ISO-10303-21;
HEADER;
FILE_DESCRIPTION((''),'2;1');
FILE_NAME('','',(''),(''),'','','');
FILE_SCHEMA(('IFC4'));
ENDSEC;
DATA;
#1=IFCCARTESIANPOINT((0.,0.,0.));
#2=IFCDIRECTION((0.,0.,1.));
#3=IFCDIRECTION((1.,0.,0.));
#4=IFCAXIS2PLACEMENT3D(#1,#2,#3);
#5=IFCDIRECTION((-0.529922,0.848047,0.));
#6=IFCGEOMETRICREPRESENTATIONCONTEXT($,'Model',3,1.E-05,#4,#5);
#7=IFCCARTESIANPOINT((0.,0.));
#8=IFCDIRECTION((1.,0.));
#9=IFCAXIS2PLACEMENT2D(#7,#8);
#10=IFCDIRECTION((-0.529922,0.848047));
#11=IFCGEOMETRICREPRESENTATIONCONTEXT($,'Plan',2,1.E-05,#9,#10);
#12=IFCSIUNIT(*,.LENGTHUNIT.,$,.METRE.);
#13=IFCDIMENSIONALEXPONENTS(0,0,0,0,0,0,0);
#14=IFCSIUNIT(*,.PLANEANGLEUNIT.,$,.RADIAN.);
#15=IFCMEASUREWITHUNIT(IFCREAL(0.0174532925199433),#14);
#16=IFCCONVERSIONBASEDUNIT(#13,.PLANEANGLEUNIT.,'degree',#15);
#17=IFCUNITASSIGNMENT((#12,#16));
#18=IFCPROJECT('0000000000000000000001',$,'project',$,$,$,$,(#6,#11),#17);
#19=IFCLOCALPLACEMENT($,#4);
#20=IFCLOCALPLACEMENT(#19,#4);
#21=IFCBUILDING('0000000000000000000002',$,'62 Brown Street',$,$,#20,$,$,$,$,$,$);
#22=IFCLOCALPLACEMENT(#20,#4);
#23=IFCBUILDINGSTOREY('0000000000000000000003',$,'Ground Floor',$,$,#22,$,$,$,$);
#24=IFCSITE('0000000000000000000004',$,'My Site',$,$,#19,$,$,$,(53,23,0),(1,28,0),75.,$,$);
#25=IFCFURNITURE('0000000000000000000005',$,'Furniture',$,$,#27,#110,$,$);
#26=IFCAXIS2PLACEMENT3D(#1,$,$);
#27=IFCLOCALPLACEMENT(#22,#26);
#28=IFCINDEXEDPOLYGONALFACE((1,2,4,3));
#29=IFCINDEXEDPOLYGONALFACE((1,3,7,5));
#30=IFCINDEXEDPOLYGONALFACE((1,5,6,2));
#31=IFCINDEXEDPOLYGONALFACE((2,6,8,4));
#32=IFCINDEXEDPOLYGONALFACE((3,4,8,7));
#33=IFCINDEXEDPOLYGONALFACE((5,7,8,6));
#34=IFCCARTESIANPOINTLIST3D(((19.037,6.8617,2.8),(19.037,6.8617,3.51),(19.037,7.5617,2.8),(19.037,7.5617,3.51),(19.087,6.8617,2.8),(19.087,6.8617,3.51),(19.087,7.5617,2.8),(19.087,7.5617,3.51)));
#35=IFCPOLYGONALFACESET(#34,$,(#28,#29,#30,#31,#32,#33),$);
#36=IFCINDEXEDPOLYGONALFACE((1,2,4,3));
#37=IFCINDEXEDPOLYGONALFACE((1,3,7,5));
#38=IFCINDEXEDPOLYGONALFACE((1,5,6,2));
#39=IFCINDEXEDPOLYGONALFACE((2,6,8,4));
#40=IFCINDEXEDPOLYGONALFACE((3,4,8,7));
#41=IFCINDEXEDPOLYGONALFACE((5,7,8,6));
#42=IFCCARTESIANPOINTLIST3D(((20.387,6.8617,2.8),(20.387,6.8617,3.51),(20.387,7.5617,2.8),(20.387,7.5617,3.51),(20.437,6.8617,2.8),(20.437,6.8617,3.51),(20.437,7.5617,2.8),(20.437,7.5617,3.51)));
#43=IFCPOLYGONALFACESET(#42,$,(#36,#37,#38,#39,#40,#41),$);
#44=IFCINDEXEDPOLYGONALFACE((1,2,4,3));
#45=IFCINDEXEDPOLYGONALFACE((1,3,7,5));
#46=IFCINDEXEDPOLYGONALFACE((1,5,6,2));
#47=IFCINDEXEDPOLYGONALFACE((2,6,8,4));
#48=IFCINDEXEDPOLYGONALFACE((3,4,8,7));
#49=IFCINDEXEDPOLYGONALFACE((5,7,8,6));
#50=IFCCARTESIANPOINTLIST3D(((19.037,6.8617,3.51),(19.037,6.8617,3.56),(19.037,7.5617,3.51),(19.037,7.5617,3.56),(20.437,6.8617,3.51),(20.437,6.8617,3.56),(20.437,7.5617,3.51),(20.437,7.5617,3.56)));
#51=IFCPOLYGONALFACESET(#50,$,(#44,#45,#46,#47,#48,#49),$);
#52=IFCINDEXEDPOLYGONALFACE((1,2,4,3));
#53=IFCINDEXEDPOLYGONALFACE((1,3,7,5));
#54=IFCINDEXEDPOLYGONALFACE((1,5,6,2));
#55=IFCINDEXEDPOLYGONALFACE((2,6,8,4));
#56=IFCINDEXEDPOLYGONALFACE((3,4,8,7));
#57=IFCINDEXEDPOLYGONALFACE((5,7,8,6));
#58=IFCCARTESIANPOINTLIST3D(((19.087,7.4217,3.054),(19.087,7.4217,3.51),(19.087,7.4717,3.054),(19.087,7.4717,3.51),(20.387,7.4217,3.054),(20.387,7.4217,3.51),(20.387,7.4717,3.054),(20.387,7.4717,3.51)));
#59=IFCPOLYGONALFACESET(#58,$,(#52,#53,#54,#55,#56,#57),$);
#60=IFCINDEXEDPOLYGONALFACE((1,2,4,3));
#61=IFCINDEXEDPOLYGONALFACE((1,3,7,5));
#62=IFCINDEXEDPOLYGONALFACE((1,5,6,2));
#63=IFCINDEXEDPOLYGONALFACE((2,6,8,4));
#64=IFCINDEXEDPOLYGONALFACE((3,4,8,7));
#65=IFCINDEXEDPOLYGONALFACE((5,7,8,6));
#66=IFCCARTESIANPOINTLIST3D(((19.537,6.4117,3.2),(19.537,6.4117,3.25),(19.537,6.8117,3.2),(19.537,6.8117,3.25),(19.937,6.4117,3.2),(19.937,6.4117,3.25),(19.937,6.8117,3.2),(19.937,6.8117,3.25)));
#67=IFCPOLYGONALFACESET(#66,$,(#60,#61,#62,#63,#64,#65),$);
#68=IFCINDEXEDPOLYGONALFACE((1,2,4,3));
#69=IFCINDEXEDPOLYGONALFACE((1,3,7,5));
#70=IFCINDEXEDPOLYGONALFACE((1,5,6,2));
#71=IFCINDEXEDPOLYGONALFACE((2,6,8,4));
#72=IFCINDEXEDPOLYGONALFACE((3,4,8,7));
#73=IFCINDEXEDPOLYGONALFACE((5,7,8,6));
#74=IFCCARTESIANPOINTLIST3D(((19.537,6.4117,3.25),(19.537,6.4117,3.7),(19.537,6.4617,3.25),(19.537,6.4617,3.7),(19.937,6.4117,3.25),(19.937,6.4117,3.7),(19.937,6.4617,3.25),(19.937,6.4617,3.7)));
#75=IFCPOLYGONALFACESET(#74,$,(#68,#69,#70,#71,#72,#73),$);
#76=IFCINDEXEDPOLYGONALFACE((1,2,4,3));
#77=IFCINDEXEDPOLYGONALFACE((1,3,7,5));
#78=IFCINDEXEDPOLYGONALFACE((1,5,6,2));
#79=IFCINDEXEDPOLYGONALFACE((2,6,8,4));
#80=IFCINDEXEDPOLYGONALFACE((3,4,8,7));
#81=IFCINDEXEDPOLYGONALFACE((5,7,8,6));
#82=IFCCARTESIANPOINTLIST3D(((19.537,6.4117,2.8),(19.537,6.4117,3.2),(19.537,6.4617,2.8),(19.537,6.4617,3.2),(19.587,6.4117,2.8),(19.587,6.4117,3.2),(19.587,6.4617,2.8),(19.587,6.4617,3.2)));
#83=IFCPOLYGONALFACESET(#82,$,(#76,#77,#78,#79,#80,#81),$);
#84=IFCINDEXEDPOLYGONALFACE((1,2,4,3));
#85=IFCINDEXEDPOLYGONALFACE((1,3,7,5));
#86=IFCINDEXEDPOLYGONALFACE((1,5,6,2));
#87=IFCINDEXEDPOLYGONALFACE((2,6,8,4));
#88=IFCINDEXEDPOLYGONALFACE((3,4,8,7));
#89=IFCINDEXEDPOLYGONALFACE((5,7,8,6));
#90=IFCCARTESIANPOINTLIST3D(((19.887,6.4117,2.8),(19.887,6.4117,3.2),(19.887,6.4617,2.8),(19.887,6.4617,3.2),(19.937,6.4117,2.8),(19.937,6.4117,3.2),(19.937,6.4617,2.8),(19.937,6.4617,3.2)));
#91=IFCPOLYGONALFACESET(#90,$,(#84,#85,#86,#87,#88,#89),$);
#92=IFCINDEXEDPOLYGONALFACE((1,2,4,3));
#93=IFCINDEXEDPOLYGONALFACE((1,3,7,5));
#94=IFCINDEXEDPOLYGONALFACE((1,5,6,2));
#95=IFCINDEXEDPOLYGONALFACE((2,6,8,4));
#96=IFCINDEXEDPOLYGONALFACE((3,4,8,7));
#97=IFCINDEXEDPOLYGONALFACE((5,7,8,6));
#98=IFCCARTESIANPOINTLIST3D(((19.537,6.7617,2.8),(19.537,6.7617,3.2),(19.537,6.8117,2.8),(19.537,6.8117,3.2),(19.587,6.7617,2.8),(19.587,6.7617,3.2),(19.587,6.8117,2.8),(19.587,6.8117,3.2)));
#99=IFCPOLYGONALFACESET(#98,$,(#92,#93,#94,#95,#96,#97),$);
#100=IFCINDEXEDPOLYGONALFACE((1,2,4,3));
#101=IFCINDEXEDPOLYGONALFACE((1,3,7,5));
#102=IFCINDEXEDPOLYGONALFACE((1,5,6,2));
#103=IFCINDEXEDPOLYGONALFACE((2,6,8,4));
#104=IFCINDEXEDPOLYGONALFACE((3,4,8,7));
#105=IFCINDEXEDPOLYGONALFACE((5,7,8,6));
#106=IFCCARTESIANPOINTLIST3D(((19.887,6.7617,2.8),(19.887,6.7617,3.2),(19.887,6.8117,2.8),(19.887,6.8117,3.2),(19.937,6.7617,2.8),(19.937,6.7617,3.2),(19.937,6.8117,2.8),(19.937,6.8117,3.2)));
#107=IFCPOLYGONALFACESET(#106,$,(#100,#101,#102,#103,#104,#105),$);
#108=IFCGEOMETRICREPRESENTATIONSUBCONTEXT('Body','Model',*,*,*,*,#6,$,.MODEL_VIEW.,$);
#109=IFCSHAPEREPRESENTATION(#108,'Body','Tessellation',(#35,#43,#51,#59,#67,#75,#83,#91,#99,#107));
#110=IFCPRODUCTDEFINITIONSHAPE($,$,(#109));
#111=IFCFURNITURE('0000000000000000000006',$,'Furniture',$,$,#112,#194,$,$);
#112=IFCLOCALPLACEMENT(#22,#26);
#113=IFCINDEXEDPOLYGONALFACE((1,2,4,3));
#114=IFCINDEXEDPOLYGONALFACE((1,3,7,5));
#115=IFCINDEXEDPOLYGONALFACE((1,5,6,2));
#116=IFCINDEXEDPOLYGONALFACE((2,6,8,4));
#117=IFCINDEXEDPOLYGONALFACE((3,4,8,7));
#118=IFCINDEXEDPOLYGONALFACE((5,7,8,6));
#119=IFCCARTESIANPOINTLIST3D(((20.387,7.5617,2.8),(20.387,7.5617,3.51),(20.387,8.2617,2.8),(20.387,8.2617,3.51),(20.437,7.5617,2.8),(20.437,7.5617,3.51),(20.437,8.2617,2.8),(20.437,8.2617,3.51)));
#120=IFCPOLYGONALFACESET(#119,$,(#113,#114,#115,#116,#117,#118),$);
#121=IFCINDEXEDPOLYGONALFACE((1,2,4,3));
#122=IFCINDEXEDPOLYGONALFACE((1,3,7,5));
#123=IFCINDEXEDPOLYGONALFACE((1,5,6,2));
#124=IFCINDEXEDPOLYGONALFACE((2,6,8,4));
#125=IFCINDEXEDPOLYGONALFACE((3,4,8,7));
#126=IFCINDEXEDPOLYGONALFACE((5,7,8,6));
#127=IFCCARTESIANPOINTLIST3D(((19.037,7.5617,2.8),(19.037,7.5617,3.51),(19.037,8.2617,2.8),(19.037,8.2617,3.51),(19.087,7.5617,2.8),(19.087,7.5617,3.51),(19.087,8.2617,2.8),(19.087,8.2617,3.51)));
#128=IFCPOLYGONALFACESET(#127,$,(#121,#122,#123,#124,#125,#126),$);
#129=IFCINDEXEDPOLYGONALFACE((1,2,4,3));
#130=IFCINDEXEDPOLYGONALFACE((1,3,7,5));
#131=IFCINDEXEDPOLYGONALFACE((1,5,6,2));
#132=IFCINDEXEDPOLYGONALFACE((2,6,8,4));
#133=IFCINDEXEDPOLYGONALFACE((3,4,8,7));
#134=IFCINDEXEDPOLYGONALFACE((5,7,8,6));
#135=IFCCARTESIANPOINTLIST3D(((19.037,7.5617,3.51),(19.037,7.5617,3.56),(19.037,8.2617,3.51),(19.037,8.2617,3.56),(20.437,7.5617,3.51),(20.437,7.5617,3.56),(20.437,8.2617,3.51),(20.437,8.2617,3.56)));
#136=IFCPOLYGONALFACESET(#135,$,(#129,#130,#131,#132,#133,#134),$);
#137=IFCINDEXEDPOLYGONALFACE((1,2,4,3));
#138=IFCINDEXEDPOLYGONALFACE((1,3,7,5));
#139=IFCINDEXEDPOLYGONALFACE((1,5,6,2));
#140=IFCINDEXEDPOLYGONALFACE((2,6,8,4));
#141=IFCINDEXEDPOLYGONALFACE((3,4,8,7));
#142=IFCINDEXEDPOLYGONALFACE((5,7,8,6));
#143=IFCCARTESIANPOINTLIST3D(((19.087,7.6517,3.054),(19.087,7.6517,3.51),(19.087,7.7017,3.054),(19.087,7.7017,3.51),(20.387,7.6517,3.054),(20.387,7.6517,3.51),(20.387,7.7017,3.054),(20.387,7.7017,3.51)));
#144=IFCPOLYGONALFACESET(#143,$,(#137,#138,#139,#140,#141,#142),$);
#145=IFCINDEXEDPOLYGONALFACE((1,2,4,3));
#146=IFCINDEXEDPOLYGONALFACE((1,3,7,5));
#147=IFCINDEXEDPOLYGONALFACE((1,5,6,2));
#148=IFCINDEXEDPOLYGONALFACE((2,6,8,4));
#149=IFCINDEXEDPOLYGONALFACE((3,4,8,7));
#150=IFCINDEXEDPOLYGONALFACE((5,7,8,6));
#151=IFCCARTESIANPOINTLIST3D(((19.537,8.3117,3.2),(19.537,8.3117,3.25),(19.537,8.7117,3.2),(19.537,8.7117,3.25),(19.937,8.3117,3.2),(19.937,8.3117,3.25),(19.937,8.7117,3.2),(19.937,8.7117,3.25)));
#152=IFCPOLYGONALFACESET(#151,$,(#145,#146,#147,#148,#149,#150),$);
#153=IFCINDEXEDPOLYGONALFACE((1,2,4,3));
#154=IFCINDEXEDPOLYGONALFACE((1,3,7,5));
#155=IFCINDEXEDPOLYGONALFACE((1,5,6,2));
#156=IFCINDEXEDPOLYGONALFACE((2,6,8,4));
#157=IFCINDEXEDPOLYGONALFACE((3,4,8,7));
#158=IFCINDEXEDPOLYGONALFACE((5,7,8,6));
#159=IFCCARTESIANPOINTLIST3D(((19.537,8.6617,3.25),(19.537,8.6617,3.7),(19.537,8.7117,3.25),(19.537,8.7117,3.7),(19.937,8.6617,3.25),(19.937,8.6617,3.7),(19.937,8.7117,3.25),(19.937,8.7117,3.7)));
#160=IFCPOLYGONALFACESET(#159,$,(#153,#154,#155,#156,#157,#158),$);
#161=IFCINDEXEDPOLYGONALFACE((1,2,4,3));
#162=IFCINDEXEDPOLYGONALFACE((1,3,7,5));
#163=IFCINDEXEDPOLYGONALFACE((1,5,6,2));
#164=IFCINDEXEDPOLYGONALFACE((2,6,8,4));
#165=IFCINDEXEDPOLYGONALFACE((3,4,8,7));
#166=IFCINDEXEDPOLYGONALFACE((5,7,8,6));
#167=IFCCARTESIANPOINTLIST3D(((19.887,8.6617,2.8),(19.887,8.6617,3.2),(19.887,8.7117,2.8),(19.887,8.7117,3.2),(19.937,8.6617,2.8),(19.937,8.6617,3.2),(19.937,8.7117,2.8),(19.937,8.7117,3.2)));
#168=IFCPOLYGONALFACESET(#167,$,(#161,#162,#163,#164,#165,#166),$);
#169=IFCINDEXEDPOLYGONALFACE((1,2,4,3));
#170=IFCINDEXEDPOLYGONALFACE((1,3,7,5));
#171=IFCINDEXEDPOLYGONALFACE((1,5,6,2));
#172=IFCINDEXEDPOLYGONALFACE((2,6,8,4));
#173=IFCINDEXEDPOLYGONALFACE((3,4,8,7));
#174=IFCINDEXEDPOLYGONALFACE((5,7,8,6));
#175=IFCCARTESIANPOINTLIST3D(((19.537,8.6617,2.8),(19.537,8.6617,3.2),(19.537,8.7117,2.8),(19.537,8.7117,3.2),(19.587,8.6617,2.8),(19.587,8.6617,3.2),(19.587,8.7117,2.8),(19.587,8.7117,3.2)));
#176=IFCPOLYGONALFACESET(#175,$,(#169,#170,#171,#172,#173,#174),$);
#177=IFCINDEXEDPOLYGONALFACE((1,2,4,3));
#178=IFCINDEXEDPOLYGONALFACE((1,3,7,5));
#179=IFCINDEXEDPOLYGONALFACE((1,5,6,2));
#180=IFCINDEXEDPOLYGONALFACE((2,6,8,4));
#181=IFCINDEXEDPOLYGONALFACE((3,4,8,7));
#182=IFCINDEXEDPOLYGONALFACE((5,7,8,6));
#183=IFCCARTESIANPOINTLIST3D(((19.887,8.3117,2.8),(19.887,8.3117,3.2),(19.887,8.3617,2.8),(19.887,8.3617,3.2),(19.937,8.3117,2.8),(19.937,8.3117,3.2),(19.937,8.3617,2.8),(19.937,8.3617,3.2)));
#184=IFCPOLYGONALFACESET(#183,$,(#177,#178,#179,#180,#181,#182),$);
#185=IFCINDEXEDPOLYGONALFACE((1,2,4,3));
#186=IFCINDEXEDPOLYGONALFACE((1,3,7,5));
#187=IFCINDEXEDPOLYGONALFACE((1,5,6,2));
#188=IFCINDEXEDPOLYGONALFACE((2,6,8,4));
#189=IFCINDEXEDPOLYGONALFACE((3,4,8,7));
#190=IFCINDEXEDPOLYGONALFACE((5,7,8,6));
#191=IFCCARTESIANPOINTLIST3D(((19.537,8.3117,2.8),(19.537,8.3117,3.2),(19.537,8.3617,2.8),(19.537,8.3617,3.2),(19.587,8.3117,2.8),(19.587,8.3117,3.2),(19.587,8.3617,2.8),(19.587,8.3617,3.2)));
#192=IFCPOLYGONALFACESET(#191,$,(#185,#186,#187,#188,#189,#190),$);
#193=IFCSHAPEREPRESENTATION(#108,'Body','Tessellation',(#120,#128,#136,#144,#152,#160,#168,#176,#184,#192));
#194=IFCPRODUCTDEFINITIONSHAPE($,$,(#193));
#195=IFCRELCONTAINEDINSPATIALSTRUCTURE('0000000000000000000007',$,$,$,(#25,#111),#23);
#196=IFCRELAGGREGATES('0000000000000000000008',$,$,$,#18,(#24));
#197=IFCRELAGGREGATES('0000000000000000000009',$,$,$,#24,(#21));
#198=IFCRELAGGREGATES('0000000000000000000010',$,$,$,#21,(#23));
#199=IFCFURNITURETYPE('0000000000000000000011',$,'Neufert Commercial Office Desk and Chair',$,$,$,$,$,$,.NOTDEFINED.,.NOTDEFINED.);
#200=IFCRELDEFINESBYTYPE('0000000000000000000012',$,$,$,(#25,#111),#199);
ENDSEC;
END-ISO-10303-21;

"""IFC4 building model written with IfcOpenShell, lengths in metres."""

from ifc_helpers import new_model, entity, si_unit, converted_unit, direction, frame, origin_with_axes, origin_2d_with_axis, place, context, subcontext, project, spatial, line, indexed_curve, outline, extrude, shape, source, transform, mapped, type_object, type_shapes, element, save


model = new_model("IFC4")

# Units and contexts
model_context = context("Model", 3, precision=1e-05, world=origin_with_axes(), true_north=direction((-0.529922, 0.848047, 0.0)))
plan_context = context("Plan", 2, precision=1e-05, world=origin_2d_with_axis(), true_north=direction((-0.529922, 0.848047)))
body_context_1 = subcontext(model_context, "Body", "Model", "MODEL_VIEW")
body_context_2 = subcontext(plan_context, "Body", "Plan", "PLAN_VIEW")
ifc_project = project(units=[si_unit("LENGTHUNIT", "METRE"), converted_unit("PLANEANGLEUNIT", "degree", entity("IfcReal", 0.0174532925199433), si_unit("PLANEANGLEUNIT", "RADIAN"), dimensions=[0, 0, 0, 0, 0, 0, 0])], contexts=[model_context, plan_context])

# Site, building, storey
site_placement = place(None, origin_with_axes())
site = spatial("IfcSite", under=ifc_project, at=site_placement, Name="My Site", RefLatitude=(53, 23, 0), RefLongitude=(1, 28, 0), RefElevation=75.0)
building_placement = place(site_placement, origin_with_axes())
building = spatial("IfcBuilding", under=site, at=building_placement, Name="62 Brown Street")
storey_placement = place(building_placement, origin_with_axes())
storey = spatial("IfcBuildingStorey", under=building, at=storey_placement, Name="Ground Floor")

# Furniture
furniture_type_1 = type_object("IfcFurnitureType", Name="Neufert Commercial Office Desk and Chair", AssemblyPlace="NOTDEFINED", PredefinedType="NOTDEFINED")
shared_shape_1 = source(origin_with_axes(), body_context_1, "Body", "SweptSolid", [
    extrude(outline(indexed_curve([(0.0, 0.0), (0.05, 0.0), (0.05, 0.7), (0.0, 0.7)], segments=[line(1, 2, 3, 4, 1)])), frame((0.0, 0.45, 0.0), z_axis=(0.0, 0.0, 1.0), x_axis=(1.0, 0.0, 0.0)), (0.0, 0.0, 1.0), 0.71),
    extrude(outline(indexed_curve([(0.0, 0.0), (0.05, 0.0), (0.05, 0.7), (0.0, 0.7)], segments=[line(1, 2, 3, 4, 1)])), frame((1.35, 0.45, 0.0), z_axis=(0.0, 0.0, 1.0), x_axis=(1.0, 0.0, 0.0)), (0.0, 0.0, 1.0), 0.71),
    extrude(outline(indexed_curve([(0.0, 0.0), (1.4, 0.0), (1.4, 0.7), (0.0, 0.7)], segments=[line(1, 2, 3, 4, 1)])), frame((0.0, 0.45, 0.71), z_axis=(0.0, 0.0, 1.0), x_axis=(1.0, 0.0, 0.0)), (0.0, 0.0, 1.0), 0.05),
    extrude(outline(indexed_curve([(0.05, 0.56), (1.35, 0.56), (1.35, 0.61), (0.05, 0.61)], segments=[line(1, 2, 3, 4, 1)])), frame((0.0, 0.45, 0.254), z_axis=(0.0, 0.0, 1.0), x_axis=(1.0, 0.0, 0.0)), (0.0, 0.0, 1.0), 0.456),
    extrude(outline(indexed_curve([(-0.2, 0.0), (0.2, 0.0), (0.2, 0.4), (-0.2, 0.4)], segments=[line(1, 2, 3, 4, 1)])), frame((0.7, 0.0, 0.45), z_axis=(0.0, 0.0, 1.0), x_axis=(1.0, 0.0, 0.0)), (0.0, 0.0, -1.0), 0.05),
    extrude(outline(indexed_curve([(-0.2, 0.0), (0.2, 0.0), (0.2, 0.05), (-0.2, 0.05)], segments=[line(1, 2, 3, 4, 1)])), frame((0.7, 0.0, 0.9), z_axis=(0.0, 0.0, 1.0), x_axis=(1.0, 0.0, 0.0)), (0.0, 0.0, -1.0), 0.45),
    extrude(outline(indexed_curve([(-0.2, 0.0), (-0.15, 0.0), (-0.15, 0.05), (-0.2, 0.05)], segments=[line(1, 2, 3, 4, 1)])), frame((0.7, 0.0, 0.0), z_axis=(0.0, 0.0, 1.0), x_axis=(1.0, 0.0, 0.0)), (0.0, 0.0, 1.0), 0.4),
    extrude(outline(indexed_curve([(0.2, 0.0), (0.15, 0.0), (0.15, 0.05), (0.2, 0.05)], segments=[line(1, 2, 3, 4, 1)])), frame((0.7, 0.0, 0.0), z_axis=(0.0, 0.0, 1.0), x_axis=(1.0, 0.0, 0.0)), (0.0, 0.0, 1.0), 0.4),
    extrude(outline(indexed_curve([(-0.2, 0.4), (-0.15, 0.4), (-0.15, 0.35), (-0.2, 0.35)], segments=[line(1, 2, 3, 4, 1)])), frame((0.7, 0.0, 0.0), z_axis=(0.0, 0.0, 1.0), x_axis=(1.0, 0.0, 0.0)), (0.0, 0.0, 1.0), 0.4),
    extrude(outline(indexed_curve([(0.2, 0.4), (0.15, 0.4), (0.15, 0.35), (0.2, 0.35)], segments=[line(1, 2, 3, 4, 1)])), frame((0.7, 0.0, 0.0), z_axis=(0.0, 0.0, 1.0), x_axis=(1.0, 0.0, 0.0)), (0.0, 0.0, 1.0), 0.4),
])
shared_shape_2 = source(origin_with_axes(), body_context_2, "Body", "Curve2D", [
    entity("IfcIndexedPolyCurve", entity("IfcCartesianPointList2D", [[0.0, 0.45], [1.4, 0.45], [1.4, 1.15], [0.0, 1.15]]), [entity("IfcLineIndex", [1, 2, 3, 4, 1])]),
    entity("IfcIndexedPolyCurve", entity("IfcCartesianPointList2D", [[0.5, 0.4], [0.9, 0.4]])),
    entity("IfcIndexedPolyCurve", entity("IfcCartesianPointList2D", [[0.5, 0.4], [0.5, 0.2], [0.5586, 0.0586], [0.7, 0.0], [0.8414, 0.0586], [0.9, 0.2], [0.9, 0.4]]), [entity("IfcLineIndex", [1, 2]), entity("IfcArcIndex", [2, 3, 4]), entity("IfcArcIndex", [4, 5, 6]), entity("IfcLineIndex", [6, 7])]),
    entity("IfcIndexedPolyCurve", entity("IfcCartesianPointList2D", [[0.54, 0.4], [0.54, 0.2], [0.5869, 0.0869], [0.7, 0.04], [0.8131, 0.0869], [0.86, 0.2], [0.86, 0.4]]), [entity("IfcLineIndex", [1, 2]), entity("IfcArcIndex", [2, 3, 4]), entity("IfcArcIndex", [4, 5, 6]), entity("IfcLineIndex", [6, 7])]),
])
type_shapes(furniture_type_1, [shared_shape_1, shared_shape_2])
for number, where, z_axis, x_axis, name in (
    (1, (19.037, 6.4117, 2.8), (0.0, 0.0, 1.0), (1.0, 0.0, 0.0), "Furniture"),
    (2, (20.437, 8.7117, 2.8), (0.0, 0.0, 1.0), (-1.0, 0.0, 0.0), "Furniture"),
):
    element("IfcFurniture", number, at=place(storey_placement, frame(where, z_axis=z_axis, x_axis=x_axis)), inside=storey, type_object=furniture_type_1, Name=name, shapes=[
        shape(body_context_1, "Body", "MappedRepresentation", [mapped(shared_shape_1, transform((0.0, 0.0, 0.0), x_axis=(1.0, 0.0, 0.0), y_axis=(0.0, 1.0, 0.0), z_axis=(0.0, 0.0, 1.0), scale=1.0))]),
        shape(body_context_2, "Body", "MappedRepresentation", [mapped(shared_shape_2, transform((0.0, 0.0, 0.0), x_axis=(1.0, 0.0, 0.0), y_axis=(0.0, 1.0, 0.0), z_axis=(0.0, 0.0, 1.0), scale=1.0))]),
    ])

save(model, "model.ifc")
